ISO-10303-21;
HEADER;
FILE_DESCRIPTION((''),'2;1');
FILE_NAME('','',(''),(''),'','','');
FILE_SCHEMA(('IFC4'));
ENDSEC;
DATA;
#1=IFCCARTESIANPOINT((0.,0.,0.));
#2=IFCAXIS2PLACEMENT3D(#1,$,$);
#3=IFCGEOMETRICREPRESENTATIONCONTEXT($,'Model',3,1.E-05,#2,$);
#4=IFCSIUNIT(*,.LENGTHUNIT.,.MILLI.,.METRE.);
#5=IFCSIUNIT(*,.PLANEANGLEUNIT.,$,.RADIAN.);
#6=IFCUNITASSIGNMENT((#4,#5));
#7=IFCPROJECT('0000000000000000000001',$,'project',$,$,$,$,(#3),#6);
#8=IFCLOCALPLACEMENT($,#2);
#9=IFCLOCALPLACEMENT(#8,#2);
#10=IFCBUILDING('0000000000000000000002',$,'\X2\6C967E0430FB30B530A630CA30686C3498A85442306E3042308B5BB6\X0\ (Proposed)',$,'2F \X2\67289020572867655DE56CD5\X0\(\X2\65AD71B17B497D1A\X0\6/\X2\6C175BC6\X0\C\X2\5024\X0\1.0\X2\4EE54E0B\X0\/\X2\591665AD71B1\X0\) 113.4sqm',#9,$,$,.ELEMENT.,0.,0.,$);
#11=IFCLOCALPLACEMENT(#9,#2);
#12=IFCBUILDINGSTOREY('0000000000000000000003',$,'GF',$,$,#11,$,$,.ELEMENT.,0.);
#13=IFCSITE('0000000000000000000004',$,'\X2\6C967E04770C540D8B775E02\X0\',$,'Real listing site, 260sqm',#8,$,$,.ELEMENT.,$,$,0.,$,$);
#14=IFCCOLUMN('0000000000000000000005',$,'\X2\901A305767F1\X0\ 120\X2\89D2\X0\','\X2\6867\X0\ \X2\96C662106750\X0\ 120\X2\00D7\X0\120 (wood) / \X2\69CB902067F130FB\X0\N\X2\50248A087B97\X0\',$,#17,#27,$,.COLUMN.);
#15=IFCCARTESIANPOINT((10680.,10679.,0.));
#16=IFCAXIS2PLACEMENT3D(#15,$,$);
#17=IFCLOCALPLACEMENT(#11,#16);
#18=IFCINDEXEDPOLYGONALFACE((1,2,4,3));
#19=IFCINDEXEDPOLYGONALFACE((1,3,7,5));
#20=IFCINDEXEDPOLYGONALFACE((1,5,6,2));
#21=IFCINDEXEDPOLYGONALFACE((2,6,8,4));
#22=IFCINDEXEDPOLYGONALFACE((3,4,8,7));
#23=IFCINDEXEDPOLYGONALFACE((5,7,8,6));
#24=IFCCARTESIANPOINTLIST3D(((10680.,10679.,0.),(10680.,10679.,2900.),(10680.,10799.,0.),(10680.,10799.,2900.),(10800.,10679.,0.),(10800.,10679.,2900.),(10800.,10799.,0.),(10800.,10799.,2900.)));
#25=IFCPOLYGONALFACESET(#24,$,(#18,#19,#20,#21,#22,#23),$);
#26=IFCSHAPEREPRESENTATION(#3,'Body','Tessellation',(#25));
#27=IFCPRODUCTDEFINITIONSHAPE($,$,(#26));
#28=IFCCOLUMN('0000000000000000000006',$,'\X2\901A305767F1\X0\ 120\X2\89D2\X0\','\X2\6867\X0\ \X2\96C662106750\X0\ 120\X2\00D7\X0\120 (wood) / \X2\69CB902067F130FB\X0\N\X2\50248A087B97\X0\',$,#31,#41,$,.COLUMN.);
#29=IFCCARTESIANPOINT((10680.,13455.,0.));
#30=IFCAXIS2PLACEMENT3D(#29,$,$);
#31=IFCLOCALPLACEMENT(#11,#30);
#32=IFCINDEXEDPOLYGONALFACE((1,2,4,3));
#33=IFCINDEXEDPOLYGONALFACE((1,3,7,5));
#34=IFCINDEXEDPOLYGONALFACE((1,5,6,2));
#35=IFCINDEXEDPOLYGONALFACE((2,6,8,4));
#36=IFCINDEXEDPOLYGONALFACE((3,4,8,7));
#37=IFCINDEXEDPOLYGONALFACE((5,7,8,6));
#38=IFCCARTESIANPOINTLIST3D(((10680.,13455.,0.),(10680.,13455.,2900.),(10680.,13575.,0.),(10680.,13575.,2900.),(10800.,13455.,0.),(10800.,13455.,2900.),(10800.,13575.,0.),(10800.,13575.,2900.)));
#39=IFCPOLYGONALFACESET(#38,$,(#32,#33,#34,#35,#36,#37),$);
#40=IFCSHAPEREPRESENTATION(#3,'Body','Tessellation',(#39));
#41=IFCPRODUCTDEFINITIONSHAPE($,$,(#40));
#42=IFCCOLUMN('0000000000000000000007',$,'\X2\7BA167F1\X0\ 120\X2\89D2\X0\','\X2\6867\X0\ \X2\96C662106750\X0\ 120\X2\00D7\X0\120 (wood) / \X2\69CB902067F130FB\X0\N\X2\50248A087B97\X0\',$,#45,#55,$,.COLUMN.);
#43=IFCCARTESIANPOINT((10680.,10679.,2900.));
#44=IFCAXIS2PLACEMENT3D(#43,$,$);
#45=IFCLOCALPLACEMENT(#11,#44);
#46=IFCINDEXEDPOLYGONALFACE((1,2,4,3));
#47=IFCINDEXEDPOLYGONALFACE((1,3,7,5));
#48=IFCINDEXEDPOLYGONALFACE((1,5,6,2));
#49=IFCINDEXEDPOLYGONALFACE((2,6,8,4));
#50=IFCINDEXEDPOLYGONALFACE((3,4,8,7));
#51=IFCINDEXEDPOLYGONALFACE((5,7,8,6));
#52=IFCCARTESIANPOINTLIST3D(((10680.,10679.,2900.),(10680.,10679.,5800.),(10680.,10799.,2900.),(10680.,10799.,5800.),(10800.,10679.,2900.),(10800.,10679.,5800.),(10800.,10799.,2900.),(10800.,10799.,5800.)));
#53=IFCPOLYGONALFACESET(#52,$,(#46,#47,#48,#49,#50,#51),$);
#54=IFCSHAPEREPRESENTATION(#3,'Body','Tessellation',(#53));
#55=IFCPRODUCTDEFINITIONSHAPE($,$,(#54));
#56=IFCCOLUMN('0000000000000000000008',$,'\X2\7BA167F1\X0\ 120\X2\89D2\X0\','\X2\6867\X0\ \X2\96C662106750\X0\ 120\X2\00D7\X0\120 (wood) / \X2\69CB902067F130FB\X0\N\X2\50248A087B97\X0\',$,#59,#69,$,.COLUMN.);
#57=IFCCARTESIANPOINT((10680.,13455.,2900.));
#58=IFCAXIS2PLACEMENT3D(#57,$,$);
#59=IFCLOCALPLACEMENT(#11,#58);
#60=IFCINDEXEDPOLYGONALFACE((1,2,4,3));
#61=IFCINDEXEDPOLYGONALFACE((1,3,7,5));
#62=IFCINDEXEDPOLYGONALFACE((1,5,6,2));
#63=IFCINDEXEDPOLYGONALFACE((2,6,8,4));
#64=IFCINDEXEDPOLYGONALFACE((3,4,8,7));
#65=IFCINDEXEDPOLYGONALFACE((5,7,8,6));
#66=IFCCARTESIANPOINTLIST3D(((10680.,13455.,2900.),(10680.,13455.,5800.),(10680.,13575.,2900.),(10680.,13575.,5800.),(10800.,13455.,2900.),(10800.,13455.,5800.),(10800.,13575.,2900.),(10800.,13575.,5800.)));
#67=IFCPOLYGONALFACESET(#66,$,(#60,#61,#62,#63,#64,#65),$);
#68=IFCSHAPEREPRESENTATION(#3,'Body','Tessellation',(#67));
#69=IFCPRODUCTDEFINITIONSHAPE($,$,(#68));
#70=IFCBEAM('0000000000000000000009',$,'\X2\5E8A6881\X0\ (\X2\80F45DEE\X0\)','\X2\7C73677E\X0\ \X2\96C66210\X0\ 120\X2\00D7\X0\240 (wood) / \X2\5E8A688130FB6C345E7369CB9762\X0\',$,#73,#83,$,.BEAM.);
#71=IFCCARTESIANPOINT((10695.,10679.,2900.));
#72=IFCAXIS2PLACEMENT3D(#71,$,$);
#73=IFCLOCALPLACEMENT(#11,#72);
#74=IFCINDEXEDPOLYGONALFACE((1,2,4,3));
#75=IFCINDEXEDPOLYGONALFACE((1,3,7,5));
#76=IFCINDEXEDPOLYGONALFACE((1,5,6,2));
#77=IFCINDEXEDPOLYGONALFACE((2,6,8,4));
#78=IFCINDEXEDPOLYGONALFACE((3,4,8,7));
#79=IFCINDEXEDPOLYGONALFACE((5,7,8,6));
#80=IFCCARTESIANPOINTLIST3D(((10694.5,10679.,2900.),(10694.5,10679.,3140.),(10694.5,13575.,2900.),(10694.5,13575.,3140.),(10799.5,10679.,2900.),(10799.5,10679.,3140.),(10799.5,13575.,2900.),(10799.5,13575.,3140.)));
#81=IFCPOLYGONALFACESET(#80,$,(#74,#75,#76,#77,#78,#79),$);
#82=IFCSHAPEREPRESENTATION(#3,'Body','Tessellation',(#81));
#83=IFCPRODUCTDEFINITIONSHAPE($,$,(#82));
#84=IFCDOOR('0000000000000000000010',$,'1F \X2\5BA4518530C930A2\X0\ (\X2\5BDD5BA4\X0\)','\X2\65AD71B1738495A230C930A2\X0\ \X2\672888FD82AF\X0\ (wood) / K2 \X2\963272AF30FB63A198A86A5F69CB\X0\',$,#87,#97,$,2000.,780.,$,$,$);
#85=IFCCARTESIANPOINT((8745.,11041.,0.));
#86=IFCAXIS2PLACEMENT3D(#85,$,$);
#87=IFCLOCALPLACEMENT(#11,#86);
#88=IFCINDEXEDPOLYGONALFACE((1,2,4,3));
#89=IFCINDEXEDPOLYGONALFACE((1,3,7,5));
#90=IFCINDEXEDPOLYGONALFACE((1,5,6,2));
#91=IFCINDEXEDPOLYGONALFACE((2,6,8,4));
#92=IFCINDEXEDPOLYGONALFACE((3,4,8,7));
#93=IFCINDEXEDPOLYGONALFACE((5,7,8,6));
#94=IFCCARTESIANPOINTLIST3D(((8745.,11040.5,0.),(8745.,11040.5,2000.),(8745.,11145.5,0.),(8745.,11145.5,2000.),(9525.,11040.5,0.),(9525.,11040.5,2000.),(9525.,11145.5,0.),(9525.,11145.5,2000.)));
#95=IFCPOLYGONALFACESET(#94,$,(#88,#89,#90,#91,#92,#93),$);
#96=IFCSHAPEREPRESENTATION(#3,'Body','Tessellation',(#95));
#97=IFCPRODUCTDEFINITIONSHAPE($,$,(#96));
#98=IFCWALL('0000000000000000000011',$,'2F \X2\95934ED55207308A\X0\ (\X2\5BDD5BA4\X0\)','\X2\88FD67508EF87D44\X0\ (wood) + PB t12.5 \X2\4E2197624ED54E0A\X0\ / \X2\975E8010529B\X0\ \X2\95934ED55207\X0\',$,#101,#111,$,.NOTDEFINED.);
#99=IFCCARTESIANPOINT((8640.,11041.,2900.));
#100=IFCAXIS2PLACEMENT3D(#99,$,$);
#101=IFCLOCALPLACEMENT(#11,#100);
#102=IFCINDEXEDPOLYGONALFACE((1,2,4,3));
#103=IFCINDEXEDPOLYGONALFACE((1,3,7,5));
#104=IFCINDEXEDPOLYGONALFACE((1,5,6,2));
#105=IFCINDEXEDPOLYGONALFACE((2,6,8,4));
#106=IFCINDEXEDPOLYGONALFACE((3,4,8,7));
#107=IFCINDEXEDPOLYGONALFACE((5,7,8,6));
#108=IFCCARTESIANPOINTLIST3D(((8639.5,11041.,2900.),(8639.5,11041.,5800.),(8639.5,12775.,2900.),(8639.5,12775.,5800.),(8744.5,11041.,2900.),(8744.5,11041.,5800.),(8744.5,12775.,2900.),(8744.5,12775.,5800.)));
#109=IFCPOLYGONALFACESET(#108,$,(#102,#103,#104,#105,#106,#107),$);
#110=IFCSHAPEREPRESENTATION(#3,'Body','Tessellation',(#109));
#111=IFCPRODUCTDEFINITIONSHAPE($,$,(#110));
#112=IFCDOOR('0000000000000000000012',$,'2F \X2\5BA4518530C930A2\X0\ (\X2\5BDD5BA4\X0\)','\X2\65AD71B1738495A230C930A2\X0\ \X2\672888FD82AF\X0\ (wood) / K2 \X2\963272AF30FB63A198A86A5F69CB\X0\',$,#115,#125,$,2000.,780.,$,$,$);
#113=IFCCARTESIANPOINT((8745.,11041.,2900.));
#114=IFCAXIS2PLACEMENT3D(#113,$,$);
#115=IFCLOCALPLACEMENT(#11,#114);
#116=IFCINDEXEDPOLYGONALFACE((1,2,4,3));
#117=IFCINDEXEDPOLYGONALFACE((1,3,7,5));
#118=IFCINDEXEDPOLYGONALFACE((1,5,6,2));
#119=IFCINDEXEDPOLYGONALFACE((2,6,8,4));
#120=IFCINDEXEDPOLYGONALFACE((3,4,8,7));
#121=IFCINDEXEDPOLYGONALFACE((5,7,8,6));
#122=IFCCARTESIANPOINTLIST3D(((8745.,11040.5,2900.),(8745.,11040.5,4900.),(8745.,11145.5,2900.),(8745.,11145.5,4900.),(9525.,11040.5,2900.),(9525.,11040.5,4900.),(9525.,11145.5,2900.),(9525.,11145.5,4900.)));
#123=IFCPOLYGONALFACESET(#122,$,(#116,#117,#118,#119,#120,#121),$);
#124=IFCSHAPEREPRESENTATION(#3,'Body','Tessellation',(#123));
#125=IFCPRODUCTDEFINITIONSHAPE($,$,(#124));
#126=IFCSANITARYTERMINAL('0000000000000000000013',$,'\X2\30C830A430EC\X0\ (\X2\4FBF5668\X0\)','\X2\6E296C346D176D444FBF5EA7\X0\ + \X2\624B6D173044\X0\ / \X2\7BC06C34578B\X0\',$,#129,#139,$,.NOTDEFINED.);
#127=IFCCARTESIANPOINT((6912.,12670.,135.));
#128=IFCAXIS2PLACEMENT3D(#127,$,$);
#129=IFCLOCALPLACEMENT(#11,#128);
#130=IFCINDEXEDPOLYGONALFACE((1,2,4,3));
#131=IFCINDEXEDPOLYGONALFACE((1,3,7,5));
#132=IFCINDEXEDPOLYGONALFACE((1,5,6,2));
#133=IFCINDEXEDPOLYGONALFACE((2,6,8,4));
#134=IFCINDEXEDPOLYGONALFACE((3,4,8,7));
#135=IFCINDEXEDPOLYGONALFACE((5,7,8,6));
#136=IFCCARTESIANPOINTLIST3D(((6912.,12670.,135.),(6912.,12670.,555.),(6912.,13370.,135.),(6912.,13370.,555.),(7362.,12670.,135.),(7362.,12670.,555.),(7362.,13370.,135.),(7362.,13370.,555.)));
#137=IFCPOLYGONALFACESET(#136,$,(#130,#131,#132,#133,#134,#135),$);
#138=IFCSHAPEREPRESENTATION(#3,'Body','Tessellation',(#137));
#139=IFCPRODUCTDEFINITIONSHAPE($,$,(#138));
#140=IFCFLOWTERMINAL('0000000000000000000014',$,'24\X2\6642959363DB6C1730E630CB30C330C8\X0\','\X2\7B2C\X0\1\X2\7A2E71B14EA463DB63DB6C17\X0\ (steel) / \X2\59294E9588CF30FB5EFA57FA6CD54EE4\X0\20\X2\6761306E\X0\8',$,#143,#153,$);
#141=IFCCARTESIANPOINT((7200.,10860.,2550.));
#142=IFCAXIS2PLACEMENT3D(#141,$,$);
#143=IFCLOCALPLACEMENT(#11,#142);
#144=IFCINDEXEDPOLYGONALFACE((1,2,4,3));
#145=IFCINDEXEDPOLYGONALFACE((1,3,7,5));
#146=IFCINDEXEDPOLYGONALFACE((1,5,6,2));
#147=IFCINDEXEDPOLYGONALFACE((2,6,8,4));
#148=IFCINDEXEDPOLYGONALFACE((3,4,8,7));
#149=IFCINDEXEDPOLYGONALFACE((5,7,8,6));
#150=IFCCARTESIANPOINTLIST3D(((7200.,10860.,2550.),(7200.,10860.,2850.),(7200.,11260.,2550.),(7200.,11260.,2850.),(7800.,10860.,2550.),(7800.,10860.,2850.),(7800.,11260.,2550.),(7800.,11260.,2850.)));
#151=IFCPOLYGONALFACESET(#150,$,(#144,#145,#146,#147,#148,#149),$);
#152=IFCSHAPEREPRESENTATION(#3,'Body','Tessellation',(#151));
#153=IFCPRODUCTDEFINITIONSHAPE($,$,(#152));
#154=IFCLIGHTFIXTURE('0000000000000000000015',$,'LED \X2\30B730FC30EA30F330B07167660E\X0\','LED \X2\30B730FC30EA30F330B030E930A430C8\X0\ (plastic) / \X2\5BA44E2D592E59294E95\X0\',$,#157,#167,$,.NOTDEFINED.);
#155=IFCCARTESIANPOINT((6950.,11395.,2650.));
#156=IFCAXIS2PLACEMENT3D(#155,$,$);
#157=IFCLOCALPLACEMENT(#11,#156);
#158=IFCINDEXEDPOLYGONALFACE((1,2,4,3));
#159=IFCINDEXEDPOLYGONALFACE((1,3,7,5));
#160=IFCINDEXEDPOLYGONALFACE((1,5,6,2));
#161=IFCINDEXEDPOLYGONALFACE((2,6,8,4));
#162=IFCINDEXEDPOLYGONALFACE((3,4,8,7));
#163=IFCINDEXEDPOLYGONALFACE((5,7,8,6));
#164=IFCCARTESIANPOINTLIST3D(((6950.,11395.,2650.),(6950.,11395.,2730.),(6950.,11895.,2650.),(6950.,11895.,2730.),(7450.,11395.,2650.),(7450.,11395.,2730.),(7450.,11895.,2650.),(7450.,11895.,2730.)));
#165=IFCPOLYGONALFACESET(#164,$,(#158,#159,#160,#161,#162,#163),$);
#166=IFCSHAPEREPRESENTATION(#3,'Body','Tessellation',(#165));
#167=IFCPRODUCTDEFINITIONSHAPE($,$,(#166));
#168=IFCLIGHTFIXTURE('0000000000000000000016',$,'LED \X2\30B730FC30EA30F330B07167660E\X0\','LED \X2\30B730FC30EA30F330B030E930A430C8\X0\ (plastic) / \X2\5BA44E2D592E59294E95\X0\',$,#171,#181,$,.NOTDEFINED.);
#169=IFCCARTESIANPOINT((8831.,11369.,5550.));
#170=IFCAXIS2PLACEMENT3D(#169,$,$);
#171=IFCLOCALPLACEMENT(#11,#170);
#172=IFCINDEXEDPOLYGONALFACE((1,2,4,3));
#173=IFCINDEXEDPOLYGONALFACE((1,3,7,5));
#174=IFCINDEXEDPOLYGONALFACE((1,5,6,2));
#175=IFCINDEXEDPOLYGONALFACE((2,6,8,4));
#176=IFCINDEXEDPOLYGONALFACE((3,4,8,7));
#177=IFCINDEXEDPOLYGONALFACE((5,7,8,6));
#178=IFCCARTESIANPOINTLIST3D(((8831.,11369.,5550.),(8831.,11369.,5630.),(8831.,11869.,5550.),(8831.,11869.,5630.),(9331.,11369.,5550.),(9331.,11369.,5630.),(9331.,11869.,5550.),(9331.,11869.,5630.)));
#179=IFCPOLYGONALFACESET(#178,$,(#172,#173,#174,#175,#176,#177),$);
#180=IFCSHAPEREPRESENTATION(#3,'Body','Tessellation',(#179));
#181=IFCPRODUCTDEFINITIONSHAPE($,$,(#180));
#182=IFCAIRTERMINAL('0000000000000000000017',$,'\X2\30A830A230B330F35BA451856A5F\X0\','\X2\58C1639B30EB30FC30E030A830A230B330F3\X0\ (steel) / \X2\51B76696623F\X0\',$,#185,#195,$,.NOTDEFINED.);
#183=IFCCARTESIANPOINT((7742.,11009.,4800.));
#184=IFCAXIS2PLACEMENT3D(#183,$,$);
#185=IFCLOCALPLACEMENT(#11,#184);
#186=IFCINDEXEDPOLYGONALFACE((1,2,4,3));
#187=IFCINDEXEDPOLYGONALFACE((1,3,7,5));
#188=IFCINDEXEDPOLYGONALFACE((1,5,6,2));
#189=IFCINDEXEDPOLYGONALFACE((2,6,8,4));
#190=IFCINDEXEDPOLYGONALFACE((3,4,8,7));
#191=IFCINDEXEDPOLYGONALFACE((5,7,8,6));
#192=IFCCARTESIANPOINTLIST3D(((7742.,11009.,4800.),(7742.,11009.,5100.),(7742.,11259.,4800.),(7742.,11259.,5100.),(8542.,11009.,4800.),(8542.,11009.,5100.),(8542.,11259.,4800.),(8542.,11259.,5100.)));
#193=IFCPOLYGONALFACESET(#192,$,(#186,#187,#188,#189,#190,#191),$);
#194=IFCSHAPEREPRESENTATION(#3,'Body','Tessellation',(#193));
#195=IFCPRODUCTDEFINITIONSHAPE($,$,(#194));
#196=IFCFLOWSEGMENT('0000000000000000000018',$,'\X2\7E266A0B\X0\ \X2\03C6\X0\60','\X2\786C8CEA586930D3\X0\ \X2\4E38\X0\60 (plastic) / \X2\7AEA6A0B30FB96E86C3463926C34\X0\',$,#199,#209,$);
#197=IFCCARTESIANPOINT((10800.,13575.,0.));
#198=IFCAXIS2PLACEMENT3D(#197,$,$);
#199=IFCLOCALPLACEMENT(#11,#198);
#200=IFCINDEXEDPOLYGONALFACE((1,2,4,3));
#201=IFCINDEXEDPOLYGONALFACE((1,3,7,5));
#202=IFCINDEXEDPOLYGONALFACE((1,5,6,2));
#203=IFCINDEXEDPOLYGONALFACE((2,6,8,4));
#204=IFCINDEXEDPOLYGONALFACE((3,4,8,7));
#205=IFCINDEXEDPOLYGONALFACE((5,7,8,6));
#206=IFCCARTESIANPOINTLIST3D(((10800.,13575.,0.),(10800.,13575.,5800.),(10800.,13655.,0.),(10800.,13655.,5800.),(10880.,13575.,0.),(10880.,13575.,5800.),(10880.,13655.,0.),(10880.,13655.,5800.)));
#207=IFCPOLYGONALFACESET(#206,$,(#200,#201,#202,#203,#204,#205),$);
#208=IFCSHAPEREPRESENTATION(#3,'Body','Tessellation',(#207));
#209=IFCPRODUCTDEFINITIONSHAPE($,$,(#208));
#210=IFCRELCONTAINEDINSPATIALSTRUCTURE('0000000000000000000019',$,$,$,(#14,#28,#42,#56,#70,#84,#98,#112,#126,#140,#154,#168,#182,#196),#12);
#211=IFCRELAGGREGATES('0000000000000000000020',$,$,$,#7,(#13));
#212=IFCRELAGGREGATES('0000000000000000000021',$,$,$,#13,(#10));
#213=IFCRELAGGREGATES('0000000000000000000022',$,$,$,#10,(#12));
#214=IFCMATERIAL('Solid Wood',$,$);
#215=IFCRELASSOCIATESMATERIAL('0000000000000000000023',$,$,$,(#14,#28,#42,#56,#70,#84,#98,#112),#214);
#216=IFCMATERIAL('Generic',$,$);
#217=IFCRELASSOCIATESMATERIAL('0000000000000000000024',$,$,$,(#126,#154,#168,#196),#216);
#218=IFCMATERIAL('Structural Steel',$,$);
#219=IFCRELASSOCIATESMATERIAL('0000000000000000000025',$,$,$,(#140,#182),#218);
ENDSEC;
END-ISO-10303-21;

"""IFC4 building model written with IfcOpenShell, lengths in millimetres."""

from ifc_helpers import new_model, si_unit, frame, frame_2d, origin, place, context, project, spatial, rectangle, extrude, material, element, save


model = new_model("IFC4")

# Units and contexts
model_context = context("Model", 3, precision=1e-05, world=origin())
ifc_project = project(units=[si_unit("LENGTHUNIT", "METRE", prefix="MILLI"), si_unit("PLANEANGLEUNIT", "RADIAN")], contexts=[model_context])

# Site, building, storey
site_placement = place(None, origin())
site = spatial("IfcSite", under=ifc_project, at=site_placement, Name="沖縄県名護市", ObjectType="Real listing site, 260sqm", CompositionType="ELEMENT", RefElevation=0.0)
building_placement = place(site_placement, origin())
building = spatial("IfcBuilding", under=site, at=building_placement, Name="沖縄・サウナと水風呂のある家 (Proposed)", ObjectType="2F 木造在来工法(断熱等級6/気密C値1.0以下/外断熱) 113.4sqm", CompositionType="ELEMENT", ElevationOfRefHeight=0.0, ElevationOfTerrain=0.0)
storey_placement = place(building_placement, origin())
storey = spatial("IfcBuildingStorey", under=building, at=storey_placement, Name="GF", CompositionType="ELEMENT", Elevation=0.0)

# Columns
ifc_material_1 = material(Name="Solid Wood")
column_1_placement = place(storey_placement, frame((10680.0, 10679.0, 0.0)))
element("IfcColumn", 1, at=column_1_placement, inside=storey, material=ifc_material_1, Name="通し柱 120角", Description="桧 集成材 120×120 (wood) / 構造柱・N値計算", PredefinedType="COLUMN", context=model_context, shape_type="SweptSolid", body=[
    extrude(rectangle(XDim=120.0, YDim=120.0, at=frame_2d((60.0, 60.0))), frame((10680.0, 10679.0, 0.0)), (0.0, 0.0, 1.0), 2900.0),
])
column_2_placement = place(storey_placement, frame((10680.0, 13455.0, 0.0)))
element("IfcColumn", 2, at=column_2_placement, inside=storey, material=ifc_material_1, Name="通し柱 120角", Description="桧 集成材 120×120 (wood) / 構造柱・N値計算", PredefinedType="COLUMN", context=model_context, shape_type="SweptSolid", body=[
    extrude(rectangle(XDim=120.0, YDim=120.0, at=frame_2d((60.0, 60.0))), frame((10680.0, 13455.0, 0.0)), (0.0, 0.0, 1.0), 2900.0),
])
column_3_placement = place(storey_placement, frame((10680.0, 10679.0, 2900.0)))
element("IfcColumn", 3, at=column_3_placement, inside=storey, material=ifc_material_1, Name="管柱 120角", Description="桧 集成材 120×120 (wood) / 構造柱・N値計算", PredefinedType="COLUMN", context=model_context, shape_type="SweptSolid", body=[
    extrude(rectangle(XDim=120.0, YDim=120.0, at=frame_2d((60.0, 60.0))), frame((10680.0, 10679.0, 2900.0)), (0.0, 0.0, 1.0), 2900.0),
])
column_4_placement = place(storey_placement, frame((10680.0, 13455.0, 2900.0)))
element("IfcColumn", 4, at=column_4_placement, inside=storey, material=ifc_material_1, Name="管柱 120角", Description="桧 集成材 120×120 (wood) / 構造柱・N値計算", PredefinedType="COLUMN", context=model_context, shape_type="SweptSolid", body=[
    extrude(rectangle(XDim=120.0, YDim=120.0, at=frame_2d((60.0, 60.0))), frame((10680.0, 13455.0, 2900.0)), (0.0, 0.0, 1.0), 2900.0),
])

# Beam
beam_1_placement = place(storey_placement, frame((10695.0, 10679.0, 2900.0)))
element("IfcBeam", 5, at=beam_1_placement, inside=storey, material=ifc_material_1, Name="床梁 (胴差)", Description="米松 集成 120×240 (wood) / 床梁・水平構面", PredefinedType="BEAM", context=model_context, shape_type="SweptSolid", body=[
    extrude(rectangle(XDim=105.0, YDim=2896.0, at=frame_2d((52.0, 1448.0))), frame((10695.0, 10679.0, 2900.0)), (0.0, 0.0, 1.0), 240.0),
])

# Door
door_1_placement = place(storey_placement, frame((8745.0, 11041.0, 0.0)))
element("IfcDoor", 6, at=door_1_placement, inside=storey, material=ifc_material_1, Name="1F 室内ドア (寝室)", Description="断熱玄関ドア 木製芯 (wood) / K2 防犯・採風機構", OverallHeight=2000.0, OverallWidth=780.0, context=model_context, shape_type="SweptSolid", body=[
    extrude(rectangle(XDim=780.0, YDim=105.0, at=frame_2d((390.0, 52.0))), frame((8745.0, 11041.0, 0.0)), (0.0, 0.0, 1.0), 2000.0),
])

# Wall
wall_1_placement = place(storey_placement, frame((8640.0, 11041.0, 2900.0)))
element("IfcWall", 7, at=wall_1_placement, inside=storey, material=ifc_material_1, Name="2F 間仕切り (寝室)", Description="製材軸組 (wood) + PB t12.5 両面仕上 / 非耐力 間仕切", PredefinedType="NOTDEFINED", context=model_context, shape_type="SweptSolid", body=[
    extrude(rectangle(XDim=105.0, YDim=1734.0, at=frame_2d((52.0, 867.0))), frame((8640.0, 11041.0, 2900.0)), (0.0, 0.0, 1.0), 2900.0),
])

# Door
door_2_placement = place(storey_placement, frame((8745.0, 11041.0, 2900.0)))
element("IfcDoor", 8, at=door_2_placement, inside=storey, material=ifc_material_1, Name="2F 室内ドア (寝室)", Description="断熱玄関ドア 木製芯 (wood) / K2 防犯・採風機構", OverallHeight=2000.0, OverallWidth=780.0, context=model_context, shape_type="SweptSolid", body=[
    extrude(rectangle(XDim=780.0, YDim=105.0, at=frame_2d((390.0, 52.0))), frame((8745.0, 11041.0, 2900.0)), (0.0, 0.0, 1.0), 2000.0),
])

# Sanitary terminal
ifc_material_2 = material(Name="Generic")
sanitary_terminal_placement = place(storey_placement, frame((6912.0, 12670.0, 135.0)))
element("IfcSanitaryTerminal", 9, at=sanitary_terminal_placement, inside=storey, material=ifc_material_2, Name="トイレ (便器)", Description="温水洗浄便座 + 手洗い / 節水型", PredefinedType="NOTDEFINED", context=model_context, shape_type="SweptSolid", body=[
    extrude(rectangle(XDim=450.0, YDim=700.0, at=frame_2d((225.0, 350.0))), frame((6912.0, 12670.0, 135.0)), (0.0, 0.0, 1.0), 420.0),
])

# Flow terminal
ifc_material_3 = material(Name="Structural Steel")
flow_terminal_placement = place(storey_placement, frame((7200.0, 10860.0, 2550.0)))
element("IfcFlowTerminal", 10, at=flow_terminal_placement, inside=storey, material=ifc_material_3, Name="24時間換気ユニット", Description="第1種熱交換換気 (steel) / 天井裏・建基法令20条の8", context=model_context, shape_type="SweptSolid", body=[
    extrude(rectangle(XDim=600.0, YDim=400.0, at=frame_2d((300.0, 200.0))), frame((7200.0, 10860.0, 2550.0)), (0.0, 0.0, 1.0), 300.0),
])

# Light fixtures
light_fixture_1_placement = place(storey_placement, frame((6950.0, 11395.0, 2650.0)))
element("IfcLightFixture", 11, at=light_fixture_1_placement, inside=storey, material=ifc_material_2, Name="LED シーリング照明", Description="LED シーリングライト (plastic) / 室中央天井", PredefinedType="NOTDEFINED", context=model_context, shape_type="SweptSolid", body=[
    extrude(rectangle(XDim=500.0, YDim=500.0, at=frame_2d((250.0, 250.0))), frame((6950.0, 11395.0, 2650.0)), (0.0, 0.0, 1.0), 80.0),
])
light_fixture_2_placement = place(storey_placement, frame((8831.0, 11369.0, 5550.0)))
element("IfcLightFixture", 12, at=light_fixture_2_placement, inside=storey, material=ifc_material_2, Name="LED シーリング照明", Description="LED シーリングライト (plastic) / 室中央天井", PredefinedType="NOTDEFINED", context=model_context, shape_type="SweptSolid", body=[
    extrude(rectangle(XDim=500.0, YDim=500.0, at=frame_2d((250.0, 250.0))), frame((8831.0, 11369.0, 5550.0)), (0.0, 0.0, 1.0), 80.0),
])

# Air terminal
air_terminal_placement = place(storey_placement, frame((7742.0, 11009.0, 4800.0)))
element("IfcAirTerminal", 13, at=air_terminal_placement, inside=storey, material=ifc_material_3, Name="エアコン室内機", Description="壁掛ルームエアコン (steel) / 冷暖房", PredefinedType="NOTDEFINED", context=model_context, shape_type="SweptSolid", body=[
    extrude(rectangle(XDim=800.0, YDim=250.0, at=frame_2d((400.0, 125.0))), frame((7742.0, 11009.0, 4800.0)), (0.0, 0.0, 1.0), 300.0),
])

# Flow segment
flow_segment_placement = place(storey_placement, frame((10800.0, 13575.0, 0.0)))
element("IfcFlowSegment", 14, at=flow_segment_placement, inside=storey, material=ifc_material_2, Name="縦樋 φ60", Description="硬質塩ビ 丸60 (plastic) / 竪樋・雨水排水", context=model_context, shape_type="SweptSolid", body=[
    extrude(rectangle(XDim=80.0, YDim=80.0, at=frame_2d((40.0, 40.0))), frame((10800.0, 13575.0, 0.0)), (0.0, 0.0, 1.0), 5800.0),
])

save(model, "model.ifc")
